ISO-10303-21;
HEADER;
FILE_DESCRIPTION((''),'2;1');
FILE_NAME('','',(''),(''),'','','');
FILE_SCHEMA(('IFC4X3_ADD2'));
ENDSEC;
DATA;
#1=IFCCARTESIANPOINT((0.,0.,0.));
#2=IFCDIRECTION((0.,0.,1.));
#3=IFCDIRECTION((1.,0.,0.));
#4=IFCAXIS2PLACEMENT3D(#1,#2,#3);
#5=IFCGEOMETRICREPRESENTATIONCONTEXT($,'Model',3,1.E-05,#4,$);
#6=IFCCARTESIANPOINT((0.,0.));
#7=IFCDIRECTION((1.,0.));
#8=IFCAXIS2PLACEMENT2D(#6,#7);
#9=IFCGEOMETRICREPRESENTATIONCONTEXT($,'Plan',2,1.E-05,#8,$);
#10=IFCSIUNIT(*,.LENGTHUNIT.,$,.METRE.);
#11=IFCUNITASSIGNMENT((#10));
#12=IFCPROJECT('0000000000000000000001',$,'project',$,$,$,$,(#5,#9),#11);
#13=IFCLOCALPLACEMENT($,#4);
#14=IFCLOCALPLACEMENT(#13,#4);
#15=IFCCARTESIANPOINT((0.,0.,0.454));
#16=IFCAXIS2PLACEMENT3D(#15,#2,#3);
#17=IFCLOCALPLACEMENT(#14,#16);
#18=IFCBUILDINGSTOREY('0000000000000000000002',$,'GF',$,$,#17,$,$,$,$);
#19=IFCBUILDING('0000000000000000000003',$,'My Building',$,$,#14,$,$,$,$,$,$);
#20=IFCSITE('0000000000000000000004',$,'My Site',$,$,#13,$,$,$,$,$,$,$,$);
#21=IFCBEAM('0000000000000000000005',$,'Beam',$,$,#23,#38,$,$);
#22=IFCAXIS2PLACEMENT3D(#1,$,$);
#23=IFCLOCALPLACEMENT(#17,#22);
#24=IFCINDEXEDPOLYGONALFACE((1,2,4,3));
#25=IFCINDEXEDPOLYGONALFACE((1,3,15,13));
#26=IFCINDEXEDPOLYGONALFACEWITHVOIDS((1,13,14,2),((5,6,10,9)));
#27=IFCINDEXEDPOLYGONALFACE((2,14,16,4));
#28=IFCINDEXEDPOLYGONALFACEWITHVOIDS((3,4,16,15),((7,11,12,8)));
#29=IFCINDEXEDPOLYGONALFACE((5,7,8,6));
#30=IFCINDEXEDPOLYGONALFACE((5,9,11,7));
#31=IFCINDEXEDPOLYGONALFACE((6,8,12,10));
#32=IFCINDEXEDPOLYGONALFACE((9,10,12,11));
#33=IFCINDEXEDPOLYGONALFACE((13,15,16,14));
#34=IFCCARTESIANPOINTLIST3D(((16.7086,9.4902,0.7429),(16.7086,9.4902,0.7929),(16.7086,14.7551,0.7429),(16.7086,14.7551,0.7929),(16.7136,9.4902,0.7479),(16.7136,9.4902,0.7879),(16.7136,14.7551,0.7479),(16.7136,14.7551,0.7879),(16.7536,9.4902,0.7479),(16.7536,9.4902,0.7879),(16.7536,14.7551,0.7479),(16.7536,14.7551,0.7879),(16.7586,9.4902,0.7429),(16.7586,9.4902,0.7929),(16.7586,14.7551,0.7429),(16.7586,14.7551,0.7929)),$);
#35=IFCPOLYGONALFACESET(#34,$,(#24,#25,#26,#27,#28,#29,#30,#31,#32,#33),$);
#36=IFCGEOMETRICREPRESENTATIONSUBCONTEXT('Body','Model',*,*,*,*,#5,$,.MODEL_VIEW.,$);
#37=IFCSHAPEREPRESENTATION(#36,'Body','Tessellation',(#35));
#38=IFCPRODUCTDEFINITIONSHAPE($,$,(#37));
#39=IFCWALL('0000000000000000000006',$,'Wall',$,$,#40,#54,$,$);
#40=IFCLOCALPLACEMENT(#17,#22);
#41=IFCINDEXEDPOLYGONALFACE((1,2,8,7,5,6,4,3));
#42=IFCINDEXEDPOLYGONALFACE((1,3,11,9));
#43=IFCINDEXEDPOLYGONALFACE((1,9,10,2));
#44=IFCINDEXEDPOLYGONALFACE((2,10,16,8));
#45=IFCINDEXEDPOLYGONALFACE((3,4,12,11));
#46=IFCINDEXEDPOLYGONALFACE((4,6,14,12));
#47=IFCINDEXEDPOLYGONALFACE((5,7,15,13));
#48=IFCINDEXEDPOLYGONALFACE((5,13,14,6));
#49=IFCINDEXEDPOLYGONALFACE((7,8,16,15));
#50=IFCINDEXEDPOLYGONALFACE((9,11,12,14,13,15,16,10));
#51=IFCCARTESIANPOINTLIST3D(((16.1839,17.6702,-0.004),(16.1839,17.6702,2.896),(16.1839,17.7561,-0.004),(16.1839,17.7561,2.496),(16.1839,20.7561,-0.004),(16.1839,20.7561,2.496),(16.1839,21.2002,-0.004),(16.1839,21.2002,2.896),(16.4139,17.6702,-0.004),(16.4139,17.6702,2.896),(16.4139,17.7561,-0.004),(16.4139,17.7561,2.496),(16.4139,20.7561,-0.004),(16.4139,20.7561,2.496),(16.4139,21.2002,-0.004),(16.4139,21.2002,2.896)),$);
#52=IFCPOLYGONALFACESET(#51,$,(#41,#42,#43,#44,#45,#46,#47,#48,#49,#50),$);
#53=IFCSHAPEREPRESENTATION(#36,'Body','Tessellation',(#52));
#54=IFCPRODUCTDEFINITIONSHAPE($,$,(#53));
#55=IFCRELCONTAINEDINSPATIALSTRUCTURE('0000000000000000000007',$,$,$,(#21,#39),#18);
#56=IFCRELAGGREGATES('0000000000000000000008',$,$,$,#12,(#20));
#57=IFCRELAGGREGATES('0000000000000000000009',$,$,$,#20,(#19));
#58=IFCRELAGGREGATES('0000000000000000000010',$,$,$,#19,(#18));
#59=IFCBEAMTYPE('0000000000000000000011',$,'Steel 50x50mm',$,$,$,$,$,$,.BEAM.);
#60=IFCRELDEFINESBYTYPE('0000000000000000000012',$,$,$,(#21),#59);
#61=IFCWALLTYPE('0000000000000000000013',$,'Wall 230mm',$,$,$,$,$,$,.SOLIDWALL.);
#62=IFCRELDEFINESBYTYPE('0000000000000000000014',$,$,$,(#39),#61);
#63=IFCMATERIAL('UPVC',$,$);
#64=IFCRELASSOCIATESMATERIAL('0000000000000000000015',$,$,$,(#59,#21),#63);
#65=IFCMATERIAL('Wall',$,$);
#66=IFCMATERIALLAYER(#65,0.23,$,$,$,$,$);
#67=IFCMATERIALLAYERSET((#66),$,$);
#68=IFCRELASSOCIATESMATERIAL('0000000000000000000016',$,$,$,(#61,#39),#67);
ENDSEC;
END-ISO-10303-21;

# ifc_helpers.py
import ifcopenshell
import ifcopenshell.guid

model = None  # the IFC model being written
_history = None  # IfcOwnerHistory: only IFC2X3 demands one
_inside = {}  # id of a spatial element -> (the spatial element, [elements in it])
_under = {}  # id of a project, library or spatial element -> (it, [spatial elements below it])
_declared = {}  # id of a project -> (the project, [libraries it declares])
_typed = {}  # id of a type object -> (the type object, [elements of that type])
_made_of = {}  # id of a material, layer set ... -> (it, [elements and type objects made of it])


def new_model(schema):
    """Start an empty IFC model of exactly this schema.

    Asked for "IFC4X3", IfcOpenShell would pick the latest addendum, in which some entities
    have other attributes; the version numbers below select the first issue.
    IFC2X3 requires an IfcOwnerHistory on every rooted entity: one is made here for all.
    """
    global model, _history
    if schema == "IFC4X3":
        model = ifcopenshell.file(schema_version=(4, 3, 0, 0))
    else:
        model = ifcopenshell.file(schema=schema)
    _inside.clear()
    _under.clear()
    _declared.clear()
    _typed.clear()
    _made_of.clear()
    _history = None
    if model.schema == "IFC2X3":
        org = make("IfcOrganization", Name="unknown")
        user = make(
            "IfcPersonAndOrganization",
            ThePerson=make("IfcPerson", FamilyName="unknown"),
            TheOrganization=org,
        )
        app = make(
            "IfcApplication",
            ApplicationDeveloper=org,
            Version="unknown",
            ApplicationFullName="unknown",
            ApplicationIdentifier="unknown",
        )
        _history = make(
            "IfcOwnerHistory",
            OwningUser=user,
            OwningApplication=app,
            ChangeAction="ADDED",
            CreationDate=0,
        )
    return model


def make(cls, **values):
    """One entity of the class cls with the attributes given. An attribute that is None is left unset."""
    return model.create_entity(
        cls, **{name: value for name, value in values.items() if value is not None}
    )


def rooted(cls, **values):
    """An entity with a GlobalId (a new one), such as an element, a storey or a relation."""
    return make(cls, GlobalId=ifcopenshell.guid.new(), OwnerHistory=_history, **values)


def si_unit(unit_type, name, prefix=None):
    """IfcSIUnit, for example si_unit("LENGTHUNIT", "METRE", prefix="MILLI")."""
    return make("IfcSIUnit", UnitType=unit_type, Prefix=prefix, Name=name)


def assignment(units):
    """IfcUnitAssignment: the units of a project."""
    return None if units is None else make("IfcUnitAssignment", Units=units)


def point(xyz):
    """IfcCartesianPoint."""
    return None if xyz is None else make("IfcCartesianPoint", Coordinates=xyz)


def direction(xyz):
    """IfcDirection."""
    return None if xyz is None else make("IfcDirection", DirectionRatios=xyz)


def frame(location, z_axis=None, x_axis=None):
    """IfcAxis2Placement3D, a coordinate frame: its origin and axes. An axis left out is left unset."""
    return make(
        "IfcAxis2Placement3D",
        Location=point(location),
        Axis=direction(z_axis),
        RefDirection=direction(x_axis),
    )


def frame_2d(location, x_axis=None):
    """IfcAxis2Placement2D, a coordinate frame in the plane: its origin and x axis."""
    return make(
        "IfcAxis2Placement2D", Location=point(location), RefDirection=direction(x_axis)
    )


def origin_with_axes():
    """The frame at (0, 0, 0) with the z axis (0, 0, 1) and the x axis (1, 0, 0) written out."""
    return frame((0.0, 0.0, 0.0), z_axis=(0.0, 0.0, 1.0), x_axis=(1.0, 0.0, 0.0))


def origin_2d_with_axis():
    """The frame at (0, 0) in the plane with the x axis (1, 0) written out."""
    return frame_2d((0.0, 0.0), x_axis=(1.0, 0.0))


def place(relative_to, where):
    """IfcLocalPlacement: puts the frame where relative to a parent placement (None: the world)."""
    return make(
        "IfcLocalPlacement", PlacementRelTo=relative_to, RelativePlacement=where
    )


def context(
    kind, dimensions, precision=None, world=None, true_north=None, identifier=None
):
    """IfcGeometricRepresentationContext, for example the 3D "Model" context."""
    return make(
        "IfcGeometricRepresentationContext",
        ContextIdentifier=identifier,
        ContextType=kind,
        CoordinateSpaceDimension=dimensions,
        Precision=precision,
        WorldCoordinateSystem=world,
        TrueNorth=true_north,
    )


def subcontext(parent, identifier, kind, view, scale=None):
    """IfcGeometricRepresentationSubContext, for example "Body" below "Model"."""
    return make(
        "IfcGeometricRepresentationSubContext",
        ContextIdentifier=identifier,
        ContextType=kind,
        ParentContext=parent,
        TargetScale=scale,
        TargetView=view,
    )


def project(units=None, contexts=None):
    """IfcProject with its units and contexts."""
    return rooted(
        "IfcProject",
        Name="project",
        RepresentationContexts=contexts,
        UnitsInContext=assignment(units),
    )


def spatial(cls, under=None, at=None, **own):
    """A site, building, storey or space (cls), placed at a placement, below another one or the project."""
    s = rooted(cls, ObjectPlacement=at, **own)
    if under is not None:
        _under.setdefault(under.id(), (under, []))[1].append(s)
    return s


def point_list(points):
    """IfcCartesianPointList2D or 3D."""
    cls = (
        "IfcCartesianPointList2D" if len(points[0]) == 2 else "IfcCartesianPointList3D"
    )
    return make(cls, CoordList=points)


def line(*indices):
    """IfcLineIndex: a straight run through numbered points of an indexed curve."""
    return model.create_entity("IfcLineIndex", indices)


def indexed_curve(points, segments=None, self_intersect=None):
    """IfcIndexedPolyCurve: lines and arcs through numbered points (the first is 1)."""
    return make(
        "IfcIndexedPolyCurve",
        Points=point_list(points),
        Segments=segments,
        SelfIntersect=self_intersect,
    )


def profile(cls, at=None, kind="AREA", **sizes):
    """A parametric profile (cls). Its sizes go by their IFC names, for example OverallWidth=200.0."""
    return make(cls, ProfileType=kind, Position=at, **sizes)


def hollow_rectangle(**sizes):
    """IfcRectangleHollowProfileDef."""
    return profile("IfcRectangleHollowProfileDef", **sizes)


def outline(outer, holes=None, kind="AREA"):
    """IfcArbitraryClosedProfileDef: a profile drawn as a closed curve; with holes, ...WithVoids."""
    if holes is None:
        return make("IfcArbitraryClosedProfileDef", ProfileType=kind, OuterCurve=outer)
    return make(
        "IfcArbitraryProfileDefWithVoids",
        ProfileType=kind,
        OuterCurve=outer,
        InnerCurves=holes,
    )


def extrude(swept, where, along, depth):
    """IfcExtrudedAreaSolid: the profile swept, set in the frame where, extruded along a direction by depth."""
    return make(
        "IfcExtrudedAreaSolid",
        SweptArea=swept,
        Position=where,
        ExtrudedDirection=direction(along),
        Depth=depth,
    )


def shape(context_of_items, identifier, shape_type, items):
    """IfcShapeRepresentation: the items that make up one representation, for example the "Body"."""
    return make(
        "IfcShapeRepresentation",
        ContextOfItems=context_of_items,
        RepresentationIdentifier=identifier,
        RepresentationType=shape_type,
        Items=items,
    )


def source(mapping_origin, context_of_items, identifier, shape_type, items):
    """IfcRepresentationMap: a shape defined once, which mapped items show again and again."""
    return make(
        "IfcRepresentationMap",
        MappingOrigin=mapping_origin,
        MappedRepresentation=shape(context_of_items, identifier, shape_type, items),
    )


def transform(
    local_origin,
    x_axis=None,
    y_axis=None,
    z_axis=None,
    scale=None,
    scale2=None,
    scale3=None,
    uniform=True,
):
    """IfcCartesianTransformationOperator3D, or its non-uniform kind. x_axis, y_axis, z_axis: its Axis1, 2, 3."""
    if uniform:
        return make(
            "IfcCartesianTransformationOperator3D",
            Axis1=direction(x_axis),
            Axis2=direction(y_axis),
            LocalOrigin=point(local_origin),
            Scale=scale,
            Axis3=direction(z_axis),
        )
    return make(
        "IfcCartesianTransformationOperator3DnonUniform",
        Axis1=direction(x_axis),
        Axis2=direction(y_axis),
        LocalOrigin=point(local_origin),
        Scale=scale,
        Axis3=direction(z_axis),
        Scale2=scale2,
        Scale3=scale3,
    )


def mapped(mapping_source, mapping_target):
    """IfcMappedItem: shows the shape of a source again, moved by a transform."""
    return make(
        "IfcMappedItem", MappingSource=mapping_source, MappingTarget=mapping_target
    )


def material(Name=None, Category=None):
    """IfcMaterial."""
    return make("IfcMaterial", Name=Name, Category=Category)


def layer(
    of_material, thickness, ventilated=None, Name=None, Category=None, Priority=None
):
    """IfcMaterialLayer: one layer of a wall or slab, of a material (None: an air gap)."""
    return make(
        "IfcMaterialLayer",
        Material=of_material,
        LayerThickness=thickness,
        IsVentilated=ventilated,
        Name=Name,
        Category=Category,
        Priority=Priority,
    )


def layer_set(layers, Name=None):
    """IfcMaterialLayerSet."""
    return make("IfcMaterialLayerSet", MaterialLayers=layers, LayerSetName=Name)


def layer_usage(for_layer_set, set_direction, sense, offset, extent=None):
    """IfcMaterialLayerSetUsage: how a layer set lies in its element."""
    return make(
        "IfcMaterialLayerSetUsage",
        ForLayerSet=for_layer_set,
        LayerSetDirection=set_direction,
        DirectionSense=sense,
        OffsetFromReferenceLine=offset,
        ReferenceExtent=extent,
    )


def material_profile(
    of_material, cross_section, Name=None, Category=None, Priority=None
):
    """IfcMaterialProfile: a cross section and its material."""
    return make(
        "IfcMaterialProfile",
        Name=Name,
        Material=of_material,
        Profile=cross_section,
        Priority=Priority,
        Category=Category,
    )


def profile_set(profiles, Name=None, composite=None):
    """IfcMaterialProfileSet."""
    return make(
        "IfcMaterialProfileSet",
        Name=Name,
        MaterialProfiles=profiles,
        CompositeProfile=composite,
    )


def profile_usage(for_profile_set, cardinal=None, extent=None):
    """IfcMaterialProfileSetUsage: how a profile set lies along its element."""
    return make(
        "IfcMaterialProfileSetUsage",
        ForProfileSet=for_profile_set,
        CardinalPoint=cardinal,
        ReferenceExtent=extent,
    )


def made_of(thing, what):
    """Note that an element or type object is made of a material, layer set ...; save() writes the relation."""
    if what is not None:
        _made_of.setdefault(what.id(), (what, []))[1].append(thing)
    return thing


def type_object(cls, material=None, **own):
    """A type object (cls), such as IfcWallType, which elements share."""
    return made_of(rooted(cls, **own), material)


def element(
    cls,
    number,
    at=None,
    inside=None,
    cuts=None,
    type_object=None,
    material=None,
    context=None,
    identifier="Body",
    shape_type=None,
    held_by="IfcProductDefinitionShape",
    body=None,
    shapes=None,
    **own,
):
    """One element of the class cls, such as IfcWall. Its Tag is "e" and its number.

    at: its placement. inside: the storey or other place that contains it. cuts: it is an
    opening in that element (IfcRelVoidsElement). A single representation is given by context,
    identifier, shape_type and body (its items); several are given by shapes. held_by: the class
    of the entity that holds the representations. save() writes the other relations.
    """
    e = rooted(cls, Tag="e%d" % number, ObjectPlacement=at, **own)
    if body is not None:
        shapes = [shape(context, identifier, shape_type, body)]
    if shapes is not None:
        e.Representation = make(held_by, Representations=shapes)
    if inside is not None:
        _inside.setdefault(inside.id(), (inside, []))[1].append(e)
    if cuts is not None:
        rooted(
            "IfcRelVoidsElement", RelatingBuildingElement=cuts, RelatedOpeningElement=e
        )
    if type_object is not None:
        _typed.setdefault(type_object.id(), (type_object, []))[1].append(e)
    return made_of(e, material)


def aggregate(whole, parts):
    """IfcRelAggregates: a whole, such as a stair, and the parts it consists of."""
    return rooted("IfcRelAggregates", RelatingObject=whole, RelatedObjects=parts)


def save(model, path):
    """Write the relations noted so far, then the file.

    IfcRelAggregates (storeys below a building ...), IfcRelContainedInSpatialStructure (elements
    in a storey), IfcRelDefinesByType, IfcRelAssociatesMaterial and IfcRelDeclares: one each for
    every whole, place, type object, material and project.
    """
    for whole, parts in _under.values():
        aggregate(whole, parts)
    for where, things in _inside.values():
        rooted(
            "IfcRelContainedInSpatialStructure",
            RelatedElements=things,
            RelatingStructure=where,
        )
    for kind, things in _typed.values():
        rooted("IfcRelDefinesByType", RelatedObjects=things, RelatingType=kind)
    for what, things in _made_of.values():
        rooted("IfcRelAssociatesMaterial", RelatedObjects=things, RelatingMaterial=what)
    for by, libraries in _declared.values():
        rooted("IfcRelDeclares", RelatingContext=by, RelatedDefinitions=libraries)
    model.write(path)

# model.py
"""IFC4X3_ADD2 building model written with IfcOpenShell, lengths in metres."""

from ifc_helpers import new_model, si_unit, frame, origin_with_axes, origin_2d_with_axis, place, context, subcontext, project, spatial, line, indexed_curve, hollow_rectangle, outline, extrude, source, transform, mapped, material, layer, layer_set, layer_usage, material_profile, profile_set, profile_usage, type_object, element, save


model = new_model("IFC4X3_ADD2")

# Units and contexts
model_context = context("Model", 3, precision=1e-05, world=origin_with_axes())
plan_context = context("Plan", 2, precision=1e-05, world=origin_2d_with_axis())
body_context = subcontext(model_context, "Body", "Model", "MODEL_VIEW")
ifc_project = project(units=[si_unit("LENGTHUNIT", "METRE")], contexts=[model_context, plan_context])

# Site, building, storey
site_placement = place(None, origin_with_axes())
site = spatial("IfcSite", under=ifc_project, at=site_placement, Name="My Site")
building_placement = place(site_placement, origin_with_axes())
building = spatial("IfcBuilding", under=site, at=building_placement, Name="My Building")
storey_placement = place(building_placement, frame((0.0, 0.0, 0.454), z_axis=(0.0, 0.0, 1.0), x_axis=(1.0, 0.0, 0.0)))
storey = spatial("IfcBuildingStorey", under=building, at=storey_placement, Name="GF")

# Shared definitions
ifc_material_1 = material(Name="UPVC")

# Beam
ifc_material_profile_1 = material_profile(ifc_material_1, hollow_rectangle(XDim=0.05, YDim=0.05, WallThickness=0.005))
ifc_profile_set_1 = profile_set([ifc_material_profile_1])
beam_type_1 = type_object("IfcBeamType", Name="Steel 50x50mm", PredefinedType="BEAM", material=ifc_profile_set_1)
ifc_profile_usage_1 = profile_usage(ifc_profile_set_1)
beam_1_placement = place(storey_placement, frame((16.7336, 14.7551, 0.7679), z_axis=(0.0, -1.0, 0.0), x_axis=(1.0, 0.0, 0.0)))
element("IfcBeam", 1, at=beam_1_placement, inside=storey, type_object=beam_type_1, material=ifc_profile_usage_1, Name="Beam", context=body_context, shape_type="SweptSolid", body=[
    extrude(hollow_rectangle(XDim=0.05, YDim=0.05, WallThickness=0.005), origin_with_axes(), (0.0, 0.0, 1.0), 5.2649),
])

# Wall, opening
ifc_material_2 = material(Name="Wall")
ifc_layer_1 = layer(ifc_material_2, 0.23)
ifc_layer_set_1 = layer_set([ifc_layer_1])
ifc_layer_usage_1 = layer_usage(ifc_layer_set_1, "AXIS2", "POSITIVE", 0.0)
wall_type = type_object("IfcWallType", Name="Wall 230mm", PredefinedType="SOLIDWALL", material=ifc_layer_set_1)
wall_placement = place(storey_placement, frame((16.4139, 17.6702, -0.004), z_axis=(0.0, 0.0, 1.0), x_axis=(0.000001, 1.0, 0.0)))
wall = element("IfcWall", 2, at=wall_placement, inside=storey, type_object=wall_type, material=ifc_layer_usage_1, Name="Wall", context=body_context, shape_type="SweptSolid", body=[
    extrude(outline(indexed_curve([(0.0, 0.0), (0.0, 0.23), (3.53, 0.23), (3.53, 0.0), (0.0, 0.0)], self_intersect=False)), origin_with_axes(), (0.0, 0.0, 1.0), 2.9),
])
shared_shape = source(origin_with_axes(), body_context, "Body", "SweptSolid", [
    extrude(outline(indexed_curve([(0.0, 0.0), (3.0, 0.0), (3.0, 2.5), (0.0, 2.5)], segments=[line(1, 2, 3, 4, 1)])), frame((0.0, -0.6, 0.0), z_axis=(0.0, -1.0, 0.0), x_axis=(1.0, 0.0, 0.0)), (0.0, 0.0, -1.0), 1.2),
])
opening_placement = place(wall_placement, frame((0.0859, 0.0, 0.0), z_axis=(0.0, 0.0, 1.0), x_axis=(1.0, 0.0, 0.0)))
element("IfcOpeningElement", 3, at=opening_placement, cuts=wall, PredefinedType="OPENING", context=body_context, shape_type="MappedRepresentation", body=[
    mapped(shared_shape, transform((0.0, 0.0, 0.0), x_axis=(1.0, 0.0, 0.0), y_axis=(0.0, 1.0, 0.0), z_axis=(0.0, 0.0, 1.0), scale=1.0)),
])

save(model, "model.ifc")
